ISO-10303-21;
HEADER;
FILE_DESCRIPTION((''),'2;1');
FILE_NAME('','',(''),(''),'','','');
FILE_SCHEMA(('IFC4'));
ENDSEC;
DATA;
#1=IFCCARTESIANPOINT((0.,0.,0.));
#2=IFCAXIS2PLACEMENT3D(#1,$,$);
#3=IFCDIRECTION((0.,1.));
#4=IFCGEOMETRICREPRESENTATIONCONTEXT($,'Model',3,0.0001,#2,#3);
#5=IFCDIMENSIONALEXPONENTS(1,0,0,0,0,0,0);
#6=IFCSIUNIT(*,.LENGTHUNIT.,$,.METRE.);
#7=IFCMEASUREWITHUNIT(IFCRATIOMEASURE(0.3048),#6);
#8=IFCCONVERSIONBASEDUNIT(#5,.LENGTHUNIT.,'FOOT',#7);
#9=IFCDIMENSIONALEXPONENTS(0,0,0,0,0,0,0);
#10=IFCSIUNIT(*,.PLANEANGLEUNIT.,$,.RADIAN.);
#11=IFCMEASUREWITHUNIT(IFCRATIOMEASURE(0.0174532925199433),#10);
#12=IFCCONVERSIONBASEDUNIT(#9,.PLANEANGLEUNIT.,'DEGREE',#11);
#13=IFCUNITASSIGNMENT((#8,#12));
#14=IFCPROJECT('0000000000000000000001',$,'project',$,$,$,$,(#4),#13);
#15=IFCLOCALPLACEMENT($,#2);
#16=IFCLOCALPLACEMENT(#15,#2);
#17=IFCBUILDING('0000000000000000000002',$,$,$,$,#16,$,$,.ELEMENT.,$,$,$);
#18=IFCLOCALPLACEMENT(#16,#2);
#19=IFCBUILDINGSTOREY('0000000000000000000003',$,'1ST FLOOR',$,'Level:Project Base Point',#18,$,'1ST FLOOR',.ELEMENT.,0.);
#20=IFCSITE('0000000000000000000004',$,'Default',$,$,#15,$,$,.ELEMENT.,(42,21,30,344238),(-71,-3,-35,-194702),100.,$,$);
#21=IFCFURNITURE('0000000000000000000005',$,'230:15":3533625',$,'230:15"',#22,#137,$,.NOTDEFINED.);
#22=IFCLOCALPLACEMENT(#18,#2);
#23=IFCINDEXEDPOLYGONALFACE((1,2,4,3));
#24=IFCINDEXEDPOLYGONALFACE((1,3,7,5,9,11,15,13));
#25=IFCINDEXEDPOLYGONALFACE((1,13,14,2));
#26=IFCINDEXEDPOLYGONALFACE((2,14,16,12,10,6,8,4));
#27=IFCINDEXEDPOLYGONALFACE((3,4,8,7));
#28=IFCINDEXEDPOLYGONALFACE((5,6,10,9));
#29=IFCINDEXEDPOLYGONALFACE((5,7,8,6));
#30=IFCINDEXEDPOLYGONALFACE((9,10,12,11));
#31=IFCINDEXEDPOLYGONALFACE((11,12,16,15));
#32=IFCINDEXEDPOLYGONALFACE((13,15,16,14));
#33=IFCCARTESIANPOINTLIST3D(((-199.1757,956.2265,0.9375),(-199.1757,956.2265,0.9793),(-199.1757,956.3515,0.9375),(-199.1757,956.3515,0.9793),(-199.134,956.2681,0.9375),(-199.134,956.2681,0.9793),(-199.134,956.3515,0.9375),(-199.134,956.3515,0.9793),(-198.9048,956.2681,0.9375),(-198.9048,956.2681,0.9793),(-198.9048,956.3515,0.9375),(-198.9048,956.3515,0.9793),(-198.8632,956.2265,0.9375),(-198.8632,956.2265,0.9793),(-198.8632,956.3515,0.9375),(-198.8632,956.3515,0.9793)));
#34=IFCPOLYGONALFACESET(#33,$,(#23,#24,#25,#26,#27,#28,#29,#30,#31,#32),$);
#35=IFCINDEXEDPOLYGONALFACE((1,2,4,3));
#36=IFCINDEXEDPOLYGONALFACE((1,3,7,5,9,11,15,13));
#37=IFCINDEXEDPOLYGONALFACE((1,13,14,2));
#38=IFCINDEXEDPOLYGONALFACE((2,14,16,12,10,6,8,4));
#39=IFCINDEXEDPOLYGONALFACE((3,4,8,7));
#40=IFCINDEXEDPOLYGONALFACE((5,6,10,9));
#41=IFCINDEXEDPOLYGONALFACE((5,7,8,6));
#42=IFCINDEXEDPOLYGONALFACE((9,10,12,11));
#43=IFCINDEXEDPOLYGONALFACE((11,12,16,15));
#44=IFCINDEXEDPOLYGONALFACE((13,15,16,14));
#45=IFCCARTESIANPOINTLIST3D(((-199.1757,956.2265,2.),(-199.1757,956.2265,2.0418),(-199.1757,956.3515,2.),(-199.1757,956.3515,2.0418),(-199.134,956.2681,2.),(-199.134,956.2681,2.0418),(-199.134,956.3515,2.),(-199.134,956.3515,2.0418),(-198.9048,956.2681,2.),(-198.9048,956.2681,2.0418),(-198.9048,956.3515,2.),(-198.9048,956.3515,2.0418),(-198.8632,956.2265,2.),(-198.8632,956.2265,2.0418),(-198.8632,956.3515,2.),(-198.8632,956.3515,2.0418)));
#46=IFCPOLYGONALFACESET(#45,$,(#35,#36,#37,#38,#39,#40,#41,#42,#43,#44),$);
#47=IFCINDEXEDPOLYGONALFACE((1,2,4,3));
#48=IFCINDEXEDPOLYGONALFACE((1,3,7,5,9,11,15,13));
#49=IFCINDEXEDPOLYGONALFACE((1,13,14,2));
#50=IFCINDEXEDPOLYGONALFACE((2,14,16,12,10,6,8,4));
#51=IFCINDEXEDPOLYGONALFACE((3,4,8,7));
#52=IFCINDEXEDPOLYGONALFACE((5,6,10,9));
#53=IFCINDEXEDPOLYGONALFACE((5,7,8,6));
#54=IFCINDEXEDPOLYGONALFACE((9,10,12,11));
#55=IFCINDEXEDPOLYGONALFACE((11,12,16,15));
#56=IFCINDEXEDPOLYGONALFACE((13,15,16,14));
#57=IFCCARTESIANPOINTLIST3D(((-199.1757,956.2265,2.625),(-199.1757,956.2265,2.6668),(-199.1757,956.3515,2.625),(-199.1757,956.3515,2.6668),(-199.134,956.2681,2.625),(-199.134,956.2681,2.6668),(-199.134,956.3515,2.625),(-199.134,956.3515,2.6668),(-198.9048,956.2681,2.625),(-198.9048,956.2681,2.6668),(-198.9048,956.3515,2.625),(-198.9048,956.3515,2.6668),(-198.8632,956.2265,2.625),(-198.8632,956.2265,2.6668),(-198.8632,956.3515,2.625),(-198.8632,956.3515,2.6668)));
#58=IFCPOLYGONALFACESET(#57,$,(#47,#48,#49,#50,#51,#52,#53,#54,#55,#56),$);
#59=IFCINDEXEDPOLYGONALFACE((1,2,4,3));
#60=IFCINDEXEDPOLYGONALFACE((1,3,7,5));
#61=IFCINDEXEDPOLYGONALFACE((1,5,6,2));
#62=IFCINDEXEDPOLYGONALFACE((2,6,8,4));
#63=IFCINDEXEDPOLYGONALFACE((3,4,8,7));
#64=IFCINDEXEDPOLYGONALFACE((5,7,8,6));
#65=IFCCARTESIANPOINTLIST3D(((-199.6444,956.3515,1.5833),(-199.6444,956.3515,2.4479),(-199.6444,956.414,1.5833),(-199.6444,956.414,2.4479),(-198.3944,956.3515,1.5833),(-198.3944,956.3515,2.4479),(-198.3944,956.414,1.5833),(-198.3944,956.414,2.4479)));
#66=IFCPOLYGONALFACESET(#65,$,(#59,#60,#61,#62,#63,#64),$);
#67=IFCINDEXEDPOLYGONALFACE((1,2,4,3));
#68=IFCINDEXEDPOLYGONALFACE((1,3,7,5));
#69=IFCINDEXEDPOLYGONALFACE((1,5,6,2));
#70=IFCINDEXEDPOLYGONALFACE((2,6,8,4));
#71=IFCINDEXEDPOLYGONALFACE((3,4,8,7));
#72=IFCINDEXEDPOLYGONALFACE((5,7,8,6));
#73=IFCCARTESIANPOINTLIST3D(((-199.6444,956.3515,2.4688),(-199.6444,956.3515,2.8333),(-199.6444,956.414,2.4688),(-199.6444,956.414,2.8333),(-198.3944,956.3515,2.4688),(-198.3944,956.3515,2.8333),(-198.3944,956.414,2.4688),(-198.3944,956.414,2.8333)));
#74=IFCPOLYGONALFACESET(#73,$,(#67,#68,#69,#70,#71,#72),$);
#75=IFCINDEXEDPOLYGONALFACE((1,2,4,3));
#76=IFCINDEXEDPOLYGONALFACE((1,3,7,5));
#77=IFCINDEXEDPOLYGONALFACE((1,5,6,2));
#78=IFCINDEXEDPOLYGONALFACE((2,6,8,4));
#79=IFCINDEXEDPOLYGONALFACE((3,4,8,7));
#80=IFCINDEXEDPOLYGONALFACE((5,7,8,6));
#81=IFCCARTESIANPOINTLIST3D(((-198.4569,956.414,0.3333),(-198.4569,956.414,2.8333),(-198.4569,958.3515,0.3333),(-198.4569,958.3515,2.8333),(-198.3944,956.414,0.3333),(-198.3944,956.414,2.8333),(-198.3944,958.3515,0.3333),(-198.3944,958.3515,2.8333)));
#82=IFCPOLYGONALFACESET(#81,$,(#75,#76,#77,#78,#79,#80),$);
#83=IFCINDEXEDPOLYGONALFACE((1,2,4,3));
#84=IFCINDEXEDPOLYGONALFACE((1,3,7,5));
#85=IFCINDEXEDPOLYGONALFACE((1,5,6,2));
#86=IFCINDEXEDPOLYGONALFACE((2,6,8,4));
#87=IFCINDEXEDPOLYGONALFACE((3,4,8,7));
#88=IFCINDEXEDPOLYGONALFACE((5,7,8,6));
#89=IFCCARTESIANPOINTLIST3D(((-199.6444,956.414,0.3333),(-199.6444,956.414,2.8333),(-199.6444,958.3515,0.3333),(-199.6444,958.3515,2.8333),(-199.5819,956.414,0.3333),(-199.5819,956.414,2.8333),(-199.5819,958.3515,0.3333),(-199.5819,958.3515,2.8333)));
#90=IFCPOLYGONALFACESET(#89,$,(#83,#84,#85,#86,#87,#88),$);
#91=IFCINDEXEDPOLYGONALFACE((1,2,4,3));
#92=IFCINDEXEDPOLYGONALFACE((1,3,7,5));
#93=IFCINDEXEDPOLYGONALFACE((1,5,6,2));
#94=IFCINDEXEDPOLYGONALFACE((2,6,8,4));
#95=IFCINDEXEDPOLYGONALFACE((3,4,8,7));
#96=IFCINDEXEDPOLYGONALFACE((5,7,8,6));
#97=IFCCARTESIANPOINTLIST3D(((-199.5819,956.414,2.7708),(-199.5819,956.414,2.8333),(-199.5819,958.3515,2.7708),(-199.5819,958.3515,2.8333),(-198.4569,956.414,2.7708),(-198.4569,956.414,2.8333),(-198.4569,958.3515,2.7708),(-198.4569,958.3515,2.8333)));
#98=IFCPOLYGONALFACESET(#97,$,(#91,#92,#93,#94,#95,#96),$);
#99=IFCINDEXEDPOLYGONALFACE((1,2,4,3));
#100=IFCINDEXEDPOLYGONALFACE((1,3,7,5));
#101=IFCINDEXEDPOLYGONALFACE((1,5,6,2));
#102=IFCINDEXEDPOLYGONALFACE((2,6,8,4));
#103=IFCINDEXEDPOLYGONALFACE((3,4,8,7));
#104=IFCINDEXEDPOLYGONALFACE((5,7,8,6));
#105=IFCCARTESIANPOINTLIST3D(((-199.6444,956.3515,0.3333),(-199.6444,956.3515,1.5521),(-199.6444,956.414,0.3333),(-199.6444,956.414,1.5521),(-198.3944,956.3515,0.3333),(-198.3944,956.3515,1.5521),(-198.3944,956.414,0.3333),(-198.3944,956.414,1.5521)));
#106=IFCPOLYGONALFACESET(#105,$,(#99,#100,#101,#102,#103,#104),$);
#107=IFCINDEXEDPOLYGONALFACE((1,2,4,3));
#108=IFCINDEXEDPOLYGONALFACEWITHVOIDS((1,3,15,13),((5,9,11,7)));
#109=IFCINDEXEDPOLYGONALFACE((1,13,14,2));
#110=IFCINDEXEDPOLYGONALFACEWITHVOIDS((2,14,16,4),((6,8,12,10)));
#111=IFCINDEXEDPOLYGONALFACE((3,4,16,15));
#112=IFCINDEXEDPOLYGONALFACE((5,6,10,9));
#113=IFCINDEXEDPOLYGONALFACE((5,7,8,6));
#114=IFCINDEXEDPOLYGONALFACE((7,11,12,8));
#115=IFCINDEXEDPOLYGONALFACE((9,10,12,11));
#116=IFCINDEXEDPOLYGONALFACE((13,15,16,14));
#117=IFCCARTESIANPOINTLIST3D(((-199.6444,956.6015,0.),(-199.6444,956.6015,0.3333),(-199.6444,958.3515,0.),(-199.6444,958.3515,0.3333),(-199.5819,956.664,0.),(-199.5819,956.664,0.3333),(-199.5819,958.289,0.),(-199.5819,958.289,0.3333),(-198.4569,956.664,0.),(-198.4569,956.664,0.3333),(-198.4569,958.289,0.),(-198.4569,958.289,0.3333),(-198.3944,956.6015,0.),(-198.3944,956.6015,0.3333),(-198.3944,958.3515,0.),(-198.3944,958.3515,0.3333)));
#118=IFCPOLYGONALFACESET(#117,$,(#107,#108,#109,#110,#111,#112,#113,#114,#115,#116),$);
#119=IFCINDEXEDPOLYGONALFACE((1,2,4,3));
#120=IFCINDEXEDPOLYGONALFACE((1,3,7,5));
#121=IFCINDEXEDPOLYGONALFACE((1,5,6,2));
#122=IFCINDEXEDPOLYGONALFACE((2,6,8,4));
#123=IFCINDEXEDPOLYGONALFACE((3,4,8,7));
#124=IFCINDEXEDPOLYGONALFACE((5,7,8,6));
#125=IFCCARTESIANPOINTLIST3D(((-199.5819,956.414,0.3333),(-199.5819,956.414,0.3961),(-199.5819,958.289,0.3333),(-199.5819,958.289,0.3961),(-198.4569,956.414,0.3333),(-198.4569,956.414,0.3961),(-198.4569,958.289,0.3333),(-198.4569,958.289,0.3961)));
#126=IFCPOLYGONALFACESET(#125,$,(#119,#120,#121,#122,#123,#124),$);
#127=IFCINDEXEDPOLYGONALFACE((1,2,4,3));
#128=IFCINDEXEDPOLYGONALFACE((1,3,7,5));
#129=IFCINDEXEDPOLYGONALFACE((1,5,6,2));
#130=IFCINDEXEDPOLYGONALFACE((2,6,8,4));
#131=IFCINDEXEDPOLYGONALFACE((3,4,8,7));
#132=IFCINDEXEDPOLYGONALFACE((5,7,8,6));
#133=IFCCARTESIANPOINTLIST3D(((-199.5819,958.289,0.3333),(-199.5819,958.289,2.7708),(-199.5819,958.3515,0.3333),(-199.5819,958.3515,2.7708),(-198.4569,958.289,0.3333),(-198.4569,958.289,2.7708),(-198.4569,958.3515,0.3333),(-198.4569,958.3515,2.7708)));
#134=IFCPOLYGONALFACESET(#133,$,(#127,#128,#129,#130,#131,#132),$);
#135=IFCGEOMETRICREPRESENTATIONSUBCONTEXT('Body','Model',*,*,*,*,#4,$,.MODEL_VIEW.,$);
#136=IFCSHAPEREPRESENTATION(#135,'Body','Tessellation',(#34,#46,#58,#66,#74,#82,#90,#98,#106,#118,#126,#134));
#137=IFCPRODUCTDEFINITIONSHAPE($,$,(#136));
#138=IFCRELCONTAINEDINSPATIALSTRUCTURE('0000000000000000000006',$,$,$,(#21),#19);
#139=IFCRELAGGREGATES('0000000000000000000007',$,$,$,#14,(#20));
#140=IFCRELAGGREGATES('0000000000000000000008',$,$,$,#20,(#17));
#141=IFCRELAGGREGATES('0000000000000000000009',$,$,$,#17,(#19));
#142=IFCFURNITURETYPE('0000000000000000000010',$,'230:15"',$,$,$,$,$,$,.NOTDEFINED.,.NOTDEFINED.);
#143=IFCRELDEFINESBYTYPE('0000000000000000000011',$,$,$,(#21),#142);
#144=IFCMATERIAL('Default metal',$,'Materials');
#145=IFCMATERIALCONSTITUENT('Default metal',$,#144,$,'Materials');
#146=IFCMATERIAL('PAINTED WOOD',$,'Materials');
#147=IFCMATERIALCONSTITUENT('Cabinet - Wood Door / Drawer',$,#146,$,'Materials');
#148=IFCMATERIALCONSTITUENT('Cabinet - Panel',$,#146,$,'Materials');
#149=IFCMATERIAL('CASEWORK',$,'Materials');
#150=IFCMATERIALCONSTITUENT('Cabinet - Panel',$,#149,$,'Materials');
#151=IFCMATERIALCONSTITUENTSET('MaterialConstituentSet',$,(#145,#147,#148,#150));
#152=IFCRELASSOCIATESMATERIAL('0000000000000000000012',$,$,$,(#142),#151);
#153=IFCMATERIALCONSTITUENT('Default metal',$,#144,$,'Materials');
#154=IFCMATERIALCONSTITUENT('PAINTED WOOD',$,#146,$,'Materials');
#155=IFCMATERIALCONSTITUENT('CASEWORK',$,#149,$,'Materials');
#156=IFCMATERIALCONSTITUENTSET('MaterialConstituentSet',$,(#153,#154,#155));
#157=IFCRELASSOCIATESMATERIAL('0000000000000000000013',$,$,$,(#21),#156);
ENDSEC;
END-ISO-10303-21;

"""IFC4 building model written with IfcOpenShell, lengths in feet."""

from ifc_helpers import new_model, entity, si_unit, converted_unit, direction, frame, frame_2d, origin, origin_2d_with_axis, place, context, subcontext, project, spatial, polyline, rectangle, outline, extrude, source, transform, mapped, material, constituent, constituent_set, type_object, type_shapes, element, save


model = new_model("IFC4")

# Units and contexts
model_context = context("Model", 3, precision=0.0001, world=origin(), true_north=direction((0.0, 1.0)))
body_context = subcontext(model_context, "Body", "Model", "MODEL_VIEW")
ifc_project = project(units=[converted_unit("LENGTHUNIT", "FOOT", entity("IfcRatioMeasure", 0.3048), si_unit("LENGTHUNIT", "METRE"), dimensions=[1, 0, 0, 0, 0, 0, 0]), converted_unit("PLANEANGLEUNIT", "DEGREE", entity("IfcRatioMeasure", 0.0174532925199433), si_unit("PLANEANGLEUNIT", "RADIAN"), dimensions=[0, 0, 0, 0, 0, 0, 0])], contexts=[model_context])

# Site, building, storey
site_placement = place(None, origin())
site = spatial("IfcSite", under=ifc_project, at=site_placement, Name="Default", CompositionType="ELEMENT", RefLatitude=(42, 21, 30, 344238), RefLongitude=(-71, -3, -35, -194702), RefElevation=100.0)
building_placement = place(site_placement, origin())
building = spatial("IfcBuilding", under=site, at=building_placement, CompositionType="ELEMENT")
storey_placement = place(building_placement, origin())
storey = spatial("IfcBuildingStorey", under=building, at=storey_placement, Name="1ST FLOOR", ObjectType="Level:Project Base Point", LongName="1ST FLOOR", CompositionType="ELEMENT", Elevation=0.0)

# Shared definitions
ifc_material_1 = material(Name="Default metal", Category="Materials")
ifc_material_2 = material(Name="PAINTED WOOD", Category="Materials")
ifc_material_3 = material(Name="CASEWORK", Category="Materials")

# Furniture
ifc_constituent_1 = constituent(ifc_material_1, Name="Default metal", Category="Materials")
ifc_constituent_2 = constituent(ifc_material_2, Name="PAINTED WOOD", Category="Materials")
ifc_constituent_3 = constituent(ifc_material_3, Name="CASEWORK", Category="Materials")
ifc_constituent_set_1 = constituent_set(constituents=[ifc_constituent_1, ifc_constituent_2, ifc_constituent_3], Name="MaterialConstituentSet")
ifc_constituent_4 = constituent(ifc_material_1, Name="Default metal", Category="Materials")
ifc_constituent_5 = constituent(ifc_material_2, Name="Cabinet - Wood Door / Drawer", Category="Materials")
ifc_constituent_6 = constituent(ifc_material_2, Name="Cabinet - Panel", Category="Materials")
ifc_constituent_7 = constituent(ifc_material_3, Name="Cabinet - Panel", Category="Materials")
ifc_constituent_set_2 = constituent_set(constituents=[ifc_constituent_4, ifc_constituent_5, ifc_constituent_6, ifc_constituent_7], Name="MaterialConstituentSet")
furniture_type_1 = type_object("IfcFurnitureType", Name="230:15\"", AssemblyPlace="NOTDEFINED", PredefinedType="NOTDEFINED", material=ifc_constituent_set_2)
shared_shape_1 = source(origin(), body_context, "Body", "SweptSolid", [
    extrude(outline(polyline([(-0.1562, -0.0521), (-0.1146, -0.0521), (-0.1146, 0.0313), (0.1146, 0.0313), (0.1146, -0.0521), (0.1562, -0.0521), (0.1562, 0.0729), (-0.1562, 0.0729), (-0.1562, -0.0521)])), frame((0.0615, 2.0521, 0.9375)), (0.0, 0.0, 1.0), 0.0418),
    extrude(outline(polyline([(-0.1562, -0.0521), (-0.1146, -0.0521), (-0.1146, 0.0313), (0.1146, 0.0313), (0.1146, -0.0521), (0.1562, -0.0521), (0.1562, 0.0729), (-0.1562, 0.0729), (-0.1562, -0.0521)])), frame((0.0615, 2.0521, 2.0)), (0.0, 0.0, 1.0), 0.0418),
    extrude(outline(polyline([(-0.1562, -0.0521), (-0.1146, -0.0521), (-0.1146, 0.0313), (0.1146, 0.0313), (0.1146, -0.0521), (0.1562, -0.0521), (0.1562, 0.0729), (-0.1562, 0.0729), (-0.1562, -0.0521)])), frame((0.0615, 2.0521, 2.625)), (0.0, 0.0, 1.0), 0.0418),
    extrude(rectangle(XDim=1.25, YDim=0.0625, at=frame_2d((0.0, 0.0), x_axis=(1.0, 0.0))), frame((0.0615, 1.9688, 1.5833), z_axis=(0.0, 0.0, 1.0), x_axis=(-1.0, 0.0, 0.0)), (0.0, 0.0, 1.0), 0.8646),
    extrude(rectangle(XDim=1.25, YDim=0.0625, at=frame_2d((0.0, 0.0), x_axis=(1.0, 0.0))), frame((0.0615, 1.9688, 2.4688), z_axis=(0.0, 0.0, 1.0), x_axis=(-1.0, 0.0, 0.0)), (0.0, 0.0, 1.0), 0.3646),
    extrude(rectangle(XDim=1.9375, YDim=0.0625, at=frame_2d((0.0, 0.0), x_axis=(1.0, 0.0))), frame((-0.5323, 0.9687, 0.3333), z_axis=(0.0, 0.0, 1.0), x_axis=(0.0, -1.0, 0.0)), (0.0, 0.0, 1.0), 2.5),
    extrude(rectangle(XDim=1.9375, YDim=0.0625, at=frame_2d((0.0, 0.0), x_axis=(1.0, 0.0))), frame((0.6552, 0.9687, 0.3333), z_axis=(0.0, 0.0, 1.0), x_axis=(0.0, -1.0, 0.0)), (0.0, 0.0, 1.0), 2.5),
    extrude(rectangle(XDim=1.9375, YDim=1.125, at=origin_2d_with_axis()), frame((0.0615, 0.9687, 2.7708), z_axis=(0.0, 0.0, 1.0), x_axis=(0.0, 1.0, 0.0)), (0.0, 0.0, 1.0), 0.0625),
    extrude(rectangle(XDim=1.25, YDim=0.0625, at=frame_2d((0.0, 0.0), x_axis=(1.0, 0.0))), frame((0.0615, 1.9688, 0.3333), z_axis=(0.0, 0.0, 1.0), x_axis=(-1.0, 0.0, 0.0)), (0.0, 0.0, 1.0), 1.2187),
    extrude(outline(polyline([(-0.875, -0.625), (0.875, -0.625), (0.875, 0.625), (-0.875, 0.625), (-0.875, -0.625)]), holes=[polyline([(-0.8125, -0.5625), (-0.8125, 0.5625), (0.8125, 0.5625), (0.8125, -0.5625), (-0.8125, -0.5625)])]), frame((0.0615, 0.875, 0.0), z_axis=(0.0, 0.0, 1.0), x_axis=(0.0, -1.0, 0.0)), (0.0, 0.0, 1.0), 0.3333),
    extrude(rectangle(XDim=1.875, YDim=1.125, at=origin_2d_with_axis()), frame((0.0615, 1.0, 0.3333), z_axis=(0.0, 0.0, 1.0), x_axis=(0.0, 1.0, 0.0)), (0.0, 0.0, 1.0), 0.0627),
    extrude(rectangle(XDim=1.125, YDim=0.0625, at=origin_2d_with_axis()), frame((0.0615, 0.0312, 0.3333), z_axis=(0.0, 0.0, 1.0), x_axis=(-1.0, 0.0, 0.0)), (0.0, 0.0, 1.0), 2.4375),
])
type_shapes(furniture_type_1, [shared_shape_1])
furniture_1_placement = place(storey_placement, frame((-198.9579, 958.3515, 0.0), z_axis=(0.0, 0.0, 1.0), x_axis=(-1.0, 0.0, 0.0)))
element("IfcFurniture", 1, at=furniture_1_placement, inside=storey, type_object=furniture_type_1, material=ifc_constituent_set_1, Name="230:15\":3533625", ObjectType="230:15\"", PredefinedType="NOTDEFINED", context=body_context, shape_type="MappedRepresentation", body=[
    mapped(shared_shape_1, transform((0.0, 0.0, 0.0), scale=1.0)),
])

save(model, "model.ifc")
